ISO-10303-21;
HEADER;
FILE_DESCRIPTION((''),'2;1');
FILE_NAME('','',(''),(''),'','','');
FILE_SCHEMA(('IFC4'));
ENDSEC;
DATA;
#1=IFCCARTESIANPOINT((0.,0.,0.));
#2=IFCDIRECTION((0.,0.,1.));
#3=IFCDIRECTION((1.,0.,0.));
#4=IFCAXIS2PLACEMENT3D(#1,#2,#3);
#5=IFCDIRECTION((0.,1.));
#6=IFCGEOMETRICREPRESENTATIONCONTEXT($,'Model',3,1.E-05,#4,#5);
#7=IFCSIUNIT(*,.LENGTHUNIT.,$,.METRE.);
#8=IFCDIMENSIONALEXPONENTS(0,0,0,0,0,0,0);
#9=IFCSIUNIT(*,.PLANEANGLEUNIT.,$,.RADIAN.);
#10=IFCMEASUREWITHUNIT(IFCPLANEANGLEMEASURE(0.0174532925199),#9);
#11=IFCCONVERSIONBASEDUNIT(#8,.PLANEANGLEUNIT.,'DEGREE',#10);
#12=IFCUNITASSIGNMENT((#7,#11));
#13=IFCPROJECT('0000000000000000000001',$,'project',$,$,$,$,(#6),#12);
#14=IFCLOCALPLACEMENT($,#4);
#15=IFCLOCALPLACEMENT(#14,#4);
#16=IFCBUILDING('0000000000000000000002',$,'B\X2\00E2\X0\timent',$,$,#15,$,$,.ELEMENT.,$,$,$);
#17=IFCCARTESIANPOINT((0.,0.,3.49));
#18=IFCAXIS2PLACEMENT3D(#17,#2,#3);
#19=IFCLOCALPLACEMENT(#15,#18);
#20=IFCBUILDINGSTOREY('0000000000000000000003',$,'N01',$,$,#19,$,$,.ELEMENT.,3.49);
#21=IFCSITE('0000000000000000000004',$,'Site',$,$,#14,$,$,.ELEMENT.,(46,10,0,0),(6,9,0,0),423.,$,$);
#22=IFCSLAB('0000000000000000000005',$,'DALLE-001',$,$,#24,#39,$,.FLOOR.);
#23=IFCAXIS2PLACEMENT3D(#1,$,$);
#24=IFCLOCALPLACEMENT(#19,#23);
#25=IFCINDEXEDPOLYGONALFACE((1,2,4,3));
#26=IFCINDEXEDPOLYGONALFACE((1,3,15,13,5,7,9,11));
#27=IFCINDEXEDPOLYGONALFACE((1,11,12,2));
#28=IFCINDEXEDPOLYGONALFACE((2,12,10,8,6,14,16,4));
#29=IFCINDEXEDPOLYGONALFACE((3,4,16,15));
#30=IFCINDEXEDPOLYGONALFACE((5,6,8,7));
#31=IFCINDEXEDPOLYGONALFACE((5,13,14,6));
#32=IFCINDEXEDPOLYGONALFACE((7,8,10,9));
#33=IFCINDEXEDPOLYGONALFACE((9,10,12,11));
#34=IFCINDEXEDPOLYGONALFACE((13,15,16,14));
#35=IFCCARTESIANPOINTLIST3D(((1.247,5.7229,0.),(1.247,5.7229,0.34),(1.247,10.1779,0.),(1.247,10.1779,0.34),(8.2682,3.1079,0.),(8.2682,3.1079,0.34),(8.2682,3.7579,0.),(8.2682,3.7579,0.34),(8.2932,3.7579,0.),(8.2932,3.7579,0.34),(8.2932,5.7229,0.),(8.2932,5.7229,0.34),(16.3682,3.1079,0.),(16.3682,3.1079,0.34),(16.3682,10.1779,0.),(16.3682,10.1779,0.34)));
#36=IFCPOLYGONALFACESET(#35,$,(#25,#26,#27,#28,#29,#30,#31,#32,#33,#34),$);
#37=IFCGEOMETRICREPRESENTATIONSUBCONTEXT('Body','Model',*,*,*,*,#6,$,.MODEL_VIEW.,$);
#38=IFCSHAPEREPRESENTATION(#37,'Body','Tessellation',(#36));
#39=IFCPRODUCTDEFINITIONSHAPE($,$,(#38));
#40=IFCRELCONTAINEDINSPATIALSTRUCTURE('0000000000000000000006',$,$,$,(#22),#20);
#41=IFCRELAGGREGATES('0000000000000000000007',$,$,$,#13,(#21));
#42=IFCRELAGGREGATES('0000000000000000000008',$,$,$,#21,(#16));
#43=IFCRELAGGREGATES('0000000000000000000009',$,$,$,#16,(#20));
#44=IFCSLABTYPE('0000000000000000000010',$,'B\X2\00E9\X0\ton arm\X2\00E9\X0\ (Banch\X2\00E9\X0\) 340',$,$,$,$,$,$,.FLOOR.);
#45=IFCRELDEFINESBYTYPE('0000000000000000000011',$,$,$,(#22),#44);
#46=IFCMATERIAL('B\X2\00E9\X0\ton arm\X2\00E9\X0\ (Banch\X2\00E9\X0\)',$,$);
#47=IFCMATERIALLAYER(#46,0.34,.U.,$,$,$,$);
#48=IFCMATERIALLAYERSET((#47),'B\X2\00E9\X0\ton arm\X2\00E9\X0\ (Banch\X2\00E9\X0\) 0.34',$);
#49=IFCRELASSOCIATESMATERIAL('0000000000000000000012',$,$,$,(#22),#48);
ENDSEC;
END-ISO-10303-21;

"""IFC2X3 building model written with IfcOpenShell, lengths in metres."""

from ifc_helpers import new_model, entity, si_unit, converted_unit, direction, frame, origin_with_axes, place, context, subcontext, project, spatial, polyline, outline, extrude, material, layer, layer_set, layer_usage, type_object, element, save


model = new_model("IFC2X3")

# Units and contexts
model_context = context("Model", 3, precision=1e-05, world=origin_with_axes(), true_north=direction((0.0, 1.0)))
body_context = subcontext(model_context, "Body", "Model", "MODEL_VIEW")
ifc_project = project(units=[si_unit("LENGTHUNIT", "METRE"), converted_unit("PLANEANGLEUNIT", "DEGREE", entity("IfcPlaneAngleMeasure", 0.0174532925199), si_unit("PLANEANGLEUNIT", "RADIAN"), dimensions=[0, 0, 0, 0, 0, 0, 0])], contexts=[model_context])

# Site, building, storey
site_placement = place(None, origin_with_axes())
site = spatial("IfcSite", under=ifc_project, at=site_placement, Name="Site", CompositionType="ELEMENT", RefLatitude=(46, 10, 0, 0), RefLongitude=(6, 9, 0, 0), RefElevation=423.0)
building_placement = place(site_placement, origin_with_axes())
building = spatial("IfcBuilding", under=site, at=building_placement, Name="Bâtiment", CompositionType="ELEMENT")
storey_placement = place(building_placement, frame((0.0, 0.0, 3.49), z_axis=(0.0, 0.0, 1.0), x_axis=(1.0, 0.0, 0.0)))
storey = spatial("IfcBuildingStorey", under=building, at=storey_placement, Name="N01", CompositionType="ELEMENT", Elevation=3.49)

# Slab
ifc_material = material(Name="Béton armé (Banché)")
ifc_layer = layer(ifc_material, 0.34, ventilated="UNKNOWN")
ifc_layer_set = layer_set([ifc_layer], Name="Béton armé (Banché) 0.34")
ifc_layer_usage = layer_usage(ifc_layer_set, "AXIS3", "NEGATIVE", 0.34)
slab_type = type_object("IfcSlabType", Name="Béton armé (Banché) 340", PredefinedType="FLOOR")
slab_placement = place(storey_placement, frame((1.247, 5.7229, 0.0), z_axis=(0.0, 0.0, 1.0), x_axis=(1.0, 0.0, 0.0)))
element("IfcSlab", 1, at=slab_placement, inside=storey, type_object=slab_type, material=ifc_layer_usage, Name="DALLE-001", PredefinedType="FLOOR", context=body_context, shape_type="SweptSolid", body=[
    extrude(outline(polyline([(0.0, 0.0), (7.0461, 0.0), (7.0461, -1.965), (7.0211, -1.965), (7.0211, -2.615), (15.1212, -2.615), (15.1212, 4.455), (0.0, 4.455), (0.0, 0.0)])), origin_with_axes(), (0.0, 0.0, 1.0), 0.34),
])

save(model, "model.ifc")
